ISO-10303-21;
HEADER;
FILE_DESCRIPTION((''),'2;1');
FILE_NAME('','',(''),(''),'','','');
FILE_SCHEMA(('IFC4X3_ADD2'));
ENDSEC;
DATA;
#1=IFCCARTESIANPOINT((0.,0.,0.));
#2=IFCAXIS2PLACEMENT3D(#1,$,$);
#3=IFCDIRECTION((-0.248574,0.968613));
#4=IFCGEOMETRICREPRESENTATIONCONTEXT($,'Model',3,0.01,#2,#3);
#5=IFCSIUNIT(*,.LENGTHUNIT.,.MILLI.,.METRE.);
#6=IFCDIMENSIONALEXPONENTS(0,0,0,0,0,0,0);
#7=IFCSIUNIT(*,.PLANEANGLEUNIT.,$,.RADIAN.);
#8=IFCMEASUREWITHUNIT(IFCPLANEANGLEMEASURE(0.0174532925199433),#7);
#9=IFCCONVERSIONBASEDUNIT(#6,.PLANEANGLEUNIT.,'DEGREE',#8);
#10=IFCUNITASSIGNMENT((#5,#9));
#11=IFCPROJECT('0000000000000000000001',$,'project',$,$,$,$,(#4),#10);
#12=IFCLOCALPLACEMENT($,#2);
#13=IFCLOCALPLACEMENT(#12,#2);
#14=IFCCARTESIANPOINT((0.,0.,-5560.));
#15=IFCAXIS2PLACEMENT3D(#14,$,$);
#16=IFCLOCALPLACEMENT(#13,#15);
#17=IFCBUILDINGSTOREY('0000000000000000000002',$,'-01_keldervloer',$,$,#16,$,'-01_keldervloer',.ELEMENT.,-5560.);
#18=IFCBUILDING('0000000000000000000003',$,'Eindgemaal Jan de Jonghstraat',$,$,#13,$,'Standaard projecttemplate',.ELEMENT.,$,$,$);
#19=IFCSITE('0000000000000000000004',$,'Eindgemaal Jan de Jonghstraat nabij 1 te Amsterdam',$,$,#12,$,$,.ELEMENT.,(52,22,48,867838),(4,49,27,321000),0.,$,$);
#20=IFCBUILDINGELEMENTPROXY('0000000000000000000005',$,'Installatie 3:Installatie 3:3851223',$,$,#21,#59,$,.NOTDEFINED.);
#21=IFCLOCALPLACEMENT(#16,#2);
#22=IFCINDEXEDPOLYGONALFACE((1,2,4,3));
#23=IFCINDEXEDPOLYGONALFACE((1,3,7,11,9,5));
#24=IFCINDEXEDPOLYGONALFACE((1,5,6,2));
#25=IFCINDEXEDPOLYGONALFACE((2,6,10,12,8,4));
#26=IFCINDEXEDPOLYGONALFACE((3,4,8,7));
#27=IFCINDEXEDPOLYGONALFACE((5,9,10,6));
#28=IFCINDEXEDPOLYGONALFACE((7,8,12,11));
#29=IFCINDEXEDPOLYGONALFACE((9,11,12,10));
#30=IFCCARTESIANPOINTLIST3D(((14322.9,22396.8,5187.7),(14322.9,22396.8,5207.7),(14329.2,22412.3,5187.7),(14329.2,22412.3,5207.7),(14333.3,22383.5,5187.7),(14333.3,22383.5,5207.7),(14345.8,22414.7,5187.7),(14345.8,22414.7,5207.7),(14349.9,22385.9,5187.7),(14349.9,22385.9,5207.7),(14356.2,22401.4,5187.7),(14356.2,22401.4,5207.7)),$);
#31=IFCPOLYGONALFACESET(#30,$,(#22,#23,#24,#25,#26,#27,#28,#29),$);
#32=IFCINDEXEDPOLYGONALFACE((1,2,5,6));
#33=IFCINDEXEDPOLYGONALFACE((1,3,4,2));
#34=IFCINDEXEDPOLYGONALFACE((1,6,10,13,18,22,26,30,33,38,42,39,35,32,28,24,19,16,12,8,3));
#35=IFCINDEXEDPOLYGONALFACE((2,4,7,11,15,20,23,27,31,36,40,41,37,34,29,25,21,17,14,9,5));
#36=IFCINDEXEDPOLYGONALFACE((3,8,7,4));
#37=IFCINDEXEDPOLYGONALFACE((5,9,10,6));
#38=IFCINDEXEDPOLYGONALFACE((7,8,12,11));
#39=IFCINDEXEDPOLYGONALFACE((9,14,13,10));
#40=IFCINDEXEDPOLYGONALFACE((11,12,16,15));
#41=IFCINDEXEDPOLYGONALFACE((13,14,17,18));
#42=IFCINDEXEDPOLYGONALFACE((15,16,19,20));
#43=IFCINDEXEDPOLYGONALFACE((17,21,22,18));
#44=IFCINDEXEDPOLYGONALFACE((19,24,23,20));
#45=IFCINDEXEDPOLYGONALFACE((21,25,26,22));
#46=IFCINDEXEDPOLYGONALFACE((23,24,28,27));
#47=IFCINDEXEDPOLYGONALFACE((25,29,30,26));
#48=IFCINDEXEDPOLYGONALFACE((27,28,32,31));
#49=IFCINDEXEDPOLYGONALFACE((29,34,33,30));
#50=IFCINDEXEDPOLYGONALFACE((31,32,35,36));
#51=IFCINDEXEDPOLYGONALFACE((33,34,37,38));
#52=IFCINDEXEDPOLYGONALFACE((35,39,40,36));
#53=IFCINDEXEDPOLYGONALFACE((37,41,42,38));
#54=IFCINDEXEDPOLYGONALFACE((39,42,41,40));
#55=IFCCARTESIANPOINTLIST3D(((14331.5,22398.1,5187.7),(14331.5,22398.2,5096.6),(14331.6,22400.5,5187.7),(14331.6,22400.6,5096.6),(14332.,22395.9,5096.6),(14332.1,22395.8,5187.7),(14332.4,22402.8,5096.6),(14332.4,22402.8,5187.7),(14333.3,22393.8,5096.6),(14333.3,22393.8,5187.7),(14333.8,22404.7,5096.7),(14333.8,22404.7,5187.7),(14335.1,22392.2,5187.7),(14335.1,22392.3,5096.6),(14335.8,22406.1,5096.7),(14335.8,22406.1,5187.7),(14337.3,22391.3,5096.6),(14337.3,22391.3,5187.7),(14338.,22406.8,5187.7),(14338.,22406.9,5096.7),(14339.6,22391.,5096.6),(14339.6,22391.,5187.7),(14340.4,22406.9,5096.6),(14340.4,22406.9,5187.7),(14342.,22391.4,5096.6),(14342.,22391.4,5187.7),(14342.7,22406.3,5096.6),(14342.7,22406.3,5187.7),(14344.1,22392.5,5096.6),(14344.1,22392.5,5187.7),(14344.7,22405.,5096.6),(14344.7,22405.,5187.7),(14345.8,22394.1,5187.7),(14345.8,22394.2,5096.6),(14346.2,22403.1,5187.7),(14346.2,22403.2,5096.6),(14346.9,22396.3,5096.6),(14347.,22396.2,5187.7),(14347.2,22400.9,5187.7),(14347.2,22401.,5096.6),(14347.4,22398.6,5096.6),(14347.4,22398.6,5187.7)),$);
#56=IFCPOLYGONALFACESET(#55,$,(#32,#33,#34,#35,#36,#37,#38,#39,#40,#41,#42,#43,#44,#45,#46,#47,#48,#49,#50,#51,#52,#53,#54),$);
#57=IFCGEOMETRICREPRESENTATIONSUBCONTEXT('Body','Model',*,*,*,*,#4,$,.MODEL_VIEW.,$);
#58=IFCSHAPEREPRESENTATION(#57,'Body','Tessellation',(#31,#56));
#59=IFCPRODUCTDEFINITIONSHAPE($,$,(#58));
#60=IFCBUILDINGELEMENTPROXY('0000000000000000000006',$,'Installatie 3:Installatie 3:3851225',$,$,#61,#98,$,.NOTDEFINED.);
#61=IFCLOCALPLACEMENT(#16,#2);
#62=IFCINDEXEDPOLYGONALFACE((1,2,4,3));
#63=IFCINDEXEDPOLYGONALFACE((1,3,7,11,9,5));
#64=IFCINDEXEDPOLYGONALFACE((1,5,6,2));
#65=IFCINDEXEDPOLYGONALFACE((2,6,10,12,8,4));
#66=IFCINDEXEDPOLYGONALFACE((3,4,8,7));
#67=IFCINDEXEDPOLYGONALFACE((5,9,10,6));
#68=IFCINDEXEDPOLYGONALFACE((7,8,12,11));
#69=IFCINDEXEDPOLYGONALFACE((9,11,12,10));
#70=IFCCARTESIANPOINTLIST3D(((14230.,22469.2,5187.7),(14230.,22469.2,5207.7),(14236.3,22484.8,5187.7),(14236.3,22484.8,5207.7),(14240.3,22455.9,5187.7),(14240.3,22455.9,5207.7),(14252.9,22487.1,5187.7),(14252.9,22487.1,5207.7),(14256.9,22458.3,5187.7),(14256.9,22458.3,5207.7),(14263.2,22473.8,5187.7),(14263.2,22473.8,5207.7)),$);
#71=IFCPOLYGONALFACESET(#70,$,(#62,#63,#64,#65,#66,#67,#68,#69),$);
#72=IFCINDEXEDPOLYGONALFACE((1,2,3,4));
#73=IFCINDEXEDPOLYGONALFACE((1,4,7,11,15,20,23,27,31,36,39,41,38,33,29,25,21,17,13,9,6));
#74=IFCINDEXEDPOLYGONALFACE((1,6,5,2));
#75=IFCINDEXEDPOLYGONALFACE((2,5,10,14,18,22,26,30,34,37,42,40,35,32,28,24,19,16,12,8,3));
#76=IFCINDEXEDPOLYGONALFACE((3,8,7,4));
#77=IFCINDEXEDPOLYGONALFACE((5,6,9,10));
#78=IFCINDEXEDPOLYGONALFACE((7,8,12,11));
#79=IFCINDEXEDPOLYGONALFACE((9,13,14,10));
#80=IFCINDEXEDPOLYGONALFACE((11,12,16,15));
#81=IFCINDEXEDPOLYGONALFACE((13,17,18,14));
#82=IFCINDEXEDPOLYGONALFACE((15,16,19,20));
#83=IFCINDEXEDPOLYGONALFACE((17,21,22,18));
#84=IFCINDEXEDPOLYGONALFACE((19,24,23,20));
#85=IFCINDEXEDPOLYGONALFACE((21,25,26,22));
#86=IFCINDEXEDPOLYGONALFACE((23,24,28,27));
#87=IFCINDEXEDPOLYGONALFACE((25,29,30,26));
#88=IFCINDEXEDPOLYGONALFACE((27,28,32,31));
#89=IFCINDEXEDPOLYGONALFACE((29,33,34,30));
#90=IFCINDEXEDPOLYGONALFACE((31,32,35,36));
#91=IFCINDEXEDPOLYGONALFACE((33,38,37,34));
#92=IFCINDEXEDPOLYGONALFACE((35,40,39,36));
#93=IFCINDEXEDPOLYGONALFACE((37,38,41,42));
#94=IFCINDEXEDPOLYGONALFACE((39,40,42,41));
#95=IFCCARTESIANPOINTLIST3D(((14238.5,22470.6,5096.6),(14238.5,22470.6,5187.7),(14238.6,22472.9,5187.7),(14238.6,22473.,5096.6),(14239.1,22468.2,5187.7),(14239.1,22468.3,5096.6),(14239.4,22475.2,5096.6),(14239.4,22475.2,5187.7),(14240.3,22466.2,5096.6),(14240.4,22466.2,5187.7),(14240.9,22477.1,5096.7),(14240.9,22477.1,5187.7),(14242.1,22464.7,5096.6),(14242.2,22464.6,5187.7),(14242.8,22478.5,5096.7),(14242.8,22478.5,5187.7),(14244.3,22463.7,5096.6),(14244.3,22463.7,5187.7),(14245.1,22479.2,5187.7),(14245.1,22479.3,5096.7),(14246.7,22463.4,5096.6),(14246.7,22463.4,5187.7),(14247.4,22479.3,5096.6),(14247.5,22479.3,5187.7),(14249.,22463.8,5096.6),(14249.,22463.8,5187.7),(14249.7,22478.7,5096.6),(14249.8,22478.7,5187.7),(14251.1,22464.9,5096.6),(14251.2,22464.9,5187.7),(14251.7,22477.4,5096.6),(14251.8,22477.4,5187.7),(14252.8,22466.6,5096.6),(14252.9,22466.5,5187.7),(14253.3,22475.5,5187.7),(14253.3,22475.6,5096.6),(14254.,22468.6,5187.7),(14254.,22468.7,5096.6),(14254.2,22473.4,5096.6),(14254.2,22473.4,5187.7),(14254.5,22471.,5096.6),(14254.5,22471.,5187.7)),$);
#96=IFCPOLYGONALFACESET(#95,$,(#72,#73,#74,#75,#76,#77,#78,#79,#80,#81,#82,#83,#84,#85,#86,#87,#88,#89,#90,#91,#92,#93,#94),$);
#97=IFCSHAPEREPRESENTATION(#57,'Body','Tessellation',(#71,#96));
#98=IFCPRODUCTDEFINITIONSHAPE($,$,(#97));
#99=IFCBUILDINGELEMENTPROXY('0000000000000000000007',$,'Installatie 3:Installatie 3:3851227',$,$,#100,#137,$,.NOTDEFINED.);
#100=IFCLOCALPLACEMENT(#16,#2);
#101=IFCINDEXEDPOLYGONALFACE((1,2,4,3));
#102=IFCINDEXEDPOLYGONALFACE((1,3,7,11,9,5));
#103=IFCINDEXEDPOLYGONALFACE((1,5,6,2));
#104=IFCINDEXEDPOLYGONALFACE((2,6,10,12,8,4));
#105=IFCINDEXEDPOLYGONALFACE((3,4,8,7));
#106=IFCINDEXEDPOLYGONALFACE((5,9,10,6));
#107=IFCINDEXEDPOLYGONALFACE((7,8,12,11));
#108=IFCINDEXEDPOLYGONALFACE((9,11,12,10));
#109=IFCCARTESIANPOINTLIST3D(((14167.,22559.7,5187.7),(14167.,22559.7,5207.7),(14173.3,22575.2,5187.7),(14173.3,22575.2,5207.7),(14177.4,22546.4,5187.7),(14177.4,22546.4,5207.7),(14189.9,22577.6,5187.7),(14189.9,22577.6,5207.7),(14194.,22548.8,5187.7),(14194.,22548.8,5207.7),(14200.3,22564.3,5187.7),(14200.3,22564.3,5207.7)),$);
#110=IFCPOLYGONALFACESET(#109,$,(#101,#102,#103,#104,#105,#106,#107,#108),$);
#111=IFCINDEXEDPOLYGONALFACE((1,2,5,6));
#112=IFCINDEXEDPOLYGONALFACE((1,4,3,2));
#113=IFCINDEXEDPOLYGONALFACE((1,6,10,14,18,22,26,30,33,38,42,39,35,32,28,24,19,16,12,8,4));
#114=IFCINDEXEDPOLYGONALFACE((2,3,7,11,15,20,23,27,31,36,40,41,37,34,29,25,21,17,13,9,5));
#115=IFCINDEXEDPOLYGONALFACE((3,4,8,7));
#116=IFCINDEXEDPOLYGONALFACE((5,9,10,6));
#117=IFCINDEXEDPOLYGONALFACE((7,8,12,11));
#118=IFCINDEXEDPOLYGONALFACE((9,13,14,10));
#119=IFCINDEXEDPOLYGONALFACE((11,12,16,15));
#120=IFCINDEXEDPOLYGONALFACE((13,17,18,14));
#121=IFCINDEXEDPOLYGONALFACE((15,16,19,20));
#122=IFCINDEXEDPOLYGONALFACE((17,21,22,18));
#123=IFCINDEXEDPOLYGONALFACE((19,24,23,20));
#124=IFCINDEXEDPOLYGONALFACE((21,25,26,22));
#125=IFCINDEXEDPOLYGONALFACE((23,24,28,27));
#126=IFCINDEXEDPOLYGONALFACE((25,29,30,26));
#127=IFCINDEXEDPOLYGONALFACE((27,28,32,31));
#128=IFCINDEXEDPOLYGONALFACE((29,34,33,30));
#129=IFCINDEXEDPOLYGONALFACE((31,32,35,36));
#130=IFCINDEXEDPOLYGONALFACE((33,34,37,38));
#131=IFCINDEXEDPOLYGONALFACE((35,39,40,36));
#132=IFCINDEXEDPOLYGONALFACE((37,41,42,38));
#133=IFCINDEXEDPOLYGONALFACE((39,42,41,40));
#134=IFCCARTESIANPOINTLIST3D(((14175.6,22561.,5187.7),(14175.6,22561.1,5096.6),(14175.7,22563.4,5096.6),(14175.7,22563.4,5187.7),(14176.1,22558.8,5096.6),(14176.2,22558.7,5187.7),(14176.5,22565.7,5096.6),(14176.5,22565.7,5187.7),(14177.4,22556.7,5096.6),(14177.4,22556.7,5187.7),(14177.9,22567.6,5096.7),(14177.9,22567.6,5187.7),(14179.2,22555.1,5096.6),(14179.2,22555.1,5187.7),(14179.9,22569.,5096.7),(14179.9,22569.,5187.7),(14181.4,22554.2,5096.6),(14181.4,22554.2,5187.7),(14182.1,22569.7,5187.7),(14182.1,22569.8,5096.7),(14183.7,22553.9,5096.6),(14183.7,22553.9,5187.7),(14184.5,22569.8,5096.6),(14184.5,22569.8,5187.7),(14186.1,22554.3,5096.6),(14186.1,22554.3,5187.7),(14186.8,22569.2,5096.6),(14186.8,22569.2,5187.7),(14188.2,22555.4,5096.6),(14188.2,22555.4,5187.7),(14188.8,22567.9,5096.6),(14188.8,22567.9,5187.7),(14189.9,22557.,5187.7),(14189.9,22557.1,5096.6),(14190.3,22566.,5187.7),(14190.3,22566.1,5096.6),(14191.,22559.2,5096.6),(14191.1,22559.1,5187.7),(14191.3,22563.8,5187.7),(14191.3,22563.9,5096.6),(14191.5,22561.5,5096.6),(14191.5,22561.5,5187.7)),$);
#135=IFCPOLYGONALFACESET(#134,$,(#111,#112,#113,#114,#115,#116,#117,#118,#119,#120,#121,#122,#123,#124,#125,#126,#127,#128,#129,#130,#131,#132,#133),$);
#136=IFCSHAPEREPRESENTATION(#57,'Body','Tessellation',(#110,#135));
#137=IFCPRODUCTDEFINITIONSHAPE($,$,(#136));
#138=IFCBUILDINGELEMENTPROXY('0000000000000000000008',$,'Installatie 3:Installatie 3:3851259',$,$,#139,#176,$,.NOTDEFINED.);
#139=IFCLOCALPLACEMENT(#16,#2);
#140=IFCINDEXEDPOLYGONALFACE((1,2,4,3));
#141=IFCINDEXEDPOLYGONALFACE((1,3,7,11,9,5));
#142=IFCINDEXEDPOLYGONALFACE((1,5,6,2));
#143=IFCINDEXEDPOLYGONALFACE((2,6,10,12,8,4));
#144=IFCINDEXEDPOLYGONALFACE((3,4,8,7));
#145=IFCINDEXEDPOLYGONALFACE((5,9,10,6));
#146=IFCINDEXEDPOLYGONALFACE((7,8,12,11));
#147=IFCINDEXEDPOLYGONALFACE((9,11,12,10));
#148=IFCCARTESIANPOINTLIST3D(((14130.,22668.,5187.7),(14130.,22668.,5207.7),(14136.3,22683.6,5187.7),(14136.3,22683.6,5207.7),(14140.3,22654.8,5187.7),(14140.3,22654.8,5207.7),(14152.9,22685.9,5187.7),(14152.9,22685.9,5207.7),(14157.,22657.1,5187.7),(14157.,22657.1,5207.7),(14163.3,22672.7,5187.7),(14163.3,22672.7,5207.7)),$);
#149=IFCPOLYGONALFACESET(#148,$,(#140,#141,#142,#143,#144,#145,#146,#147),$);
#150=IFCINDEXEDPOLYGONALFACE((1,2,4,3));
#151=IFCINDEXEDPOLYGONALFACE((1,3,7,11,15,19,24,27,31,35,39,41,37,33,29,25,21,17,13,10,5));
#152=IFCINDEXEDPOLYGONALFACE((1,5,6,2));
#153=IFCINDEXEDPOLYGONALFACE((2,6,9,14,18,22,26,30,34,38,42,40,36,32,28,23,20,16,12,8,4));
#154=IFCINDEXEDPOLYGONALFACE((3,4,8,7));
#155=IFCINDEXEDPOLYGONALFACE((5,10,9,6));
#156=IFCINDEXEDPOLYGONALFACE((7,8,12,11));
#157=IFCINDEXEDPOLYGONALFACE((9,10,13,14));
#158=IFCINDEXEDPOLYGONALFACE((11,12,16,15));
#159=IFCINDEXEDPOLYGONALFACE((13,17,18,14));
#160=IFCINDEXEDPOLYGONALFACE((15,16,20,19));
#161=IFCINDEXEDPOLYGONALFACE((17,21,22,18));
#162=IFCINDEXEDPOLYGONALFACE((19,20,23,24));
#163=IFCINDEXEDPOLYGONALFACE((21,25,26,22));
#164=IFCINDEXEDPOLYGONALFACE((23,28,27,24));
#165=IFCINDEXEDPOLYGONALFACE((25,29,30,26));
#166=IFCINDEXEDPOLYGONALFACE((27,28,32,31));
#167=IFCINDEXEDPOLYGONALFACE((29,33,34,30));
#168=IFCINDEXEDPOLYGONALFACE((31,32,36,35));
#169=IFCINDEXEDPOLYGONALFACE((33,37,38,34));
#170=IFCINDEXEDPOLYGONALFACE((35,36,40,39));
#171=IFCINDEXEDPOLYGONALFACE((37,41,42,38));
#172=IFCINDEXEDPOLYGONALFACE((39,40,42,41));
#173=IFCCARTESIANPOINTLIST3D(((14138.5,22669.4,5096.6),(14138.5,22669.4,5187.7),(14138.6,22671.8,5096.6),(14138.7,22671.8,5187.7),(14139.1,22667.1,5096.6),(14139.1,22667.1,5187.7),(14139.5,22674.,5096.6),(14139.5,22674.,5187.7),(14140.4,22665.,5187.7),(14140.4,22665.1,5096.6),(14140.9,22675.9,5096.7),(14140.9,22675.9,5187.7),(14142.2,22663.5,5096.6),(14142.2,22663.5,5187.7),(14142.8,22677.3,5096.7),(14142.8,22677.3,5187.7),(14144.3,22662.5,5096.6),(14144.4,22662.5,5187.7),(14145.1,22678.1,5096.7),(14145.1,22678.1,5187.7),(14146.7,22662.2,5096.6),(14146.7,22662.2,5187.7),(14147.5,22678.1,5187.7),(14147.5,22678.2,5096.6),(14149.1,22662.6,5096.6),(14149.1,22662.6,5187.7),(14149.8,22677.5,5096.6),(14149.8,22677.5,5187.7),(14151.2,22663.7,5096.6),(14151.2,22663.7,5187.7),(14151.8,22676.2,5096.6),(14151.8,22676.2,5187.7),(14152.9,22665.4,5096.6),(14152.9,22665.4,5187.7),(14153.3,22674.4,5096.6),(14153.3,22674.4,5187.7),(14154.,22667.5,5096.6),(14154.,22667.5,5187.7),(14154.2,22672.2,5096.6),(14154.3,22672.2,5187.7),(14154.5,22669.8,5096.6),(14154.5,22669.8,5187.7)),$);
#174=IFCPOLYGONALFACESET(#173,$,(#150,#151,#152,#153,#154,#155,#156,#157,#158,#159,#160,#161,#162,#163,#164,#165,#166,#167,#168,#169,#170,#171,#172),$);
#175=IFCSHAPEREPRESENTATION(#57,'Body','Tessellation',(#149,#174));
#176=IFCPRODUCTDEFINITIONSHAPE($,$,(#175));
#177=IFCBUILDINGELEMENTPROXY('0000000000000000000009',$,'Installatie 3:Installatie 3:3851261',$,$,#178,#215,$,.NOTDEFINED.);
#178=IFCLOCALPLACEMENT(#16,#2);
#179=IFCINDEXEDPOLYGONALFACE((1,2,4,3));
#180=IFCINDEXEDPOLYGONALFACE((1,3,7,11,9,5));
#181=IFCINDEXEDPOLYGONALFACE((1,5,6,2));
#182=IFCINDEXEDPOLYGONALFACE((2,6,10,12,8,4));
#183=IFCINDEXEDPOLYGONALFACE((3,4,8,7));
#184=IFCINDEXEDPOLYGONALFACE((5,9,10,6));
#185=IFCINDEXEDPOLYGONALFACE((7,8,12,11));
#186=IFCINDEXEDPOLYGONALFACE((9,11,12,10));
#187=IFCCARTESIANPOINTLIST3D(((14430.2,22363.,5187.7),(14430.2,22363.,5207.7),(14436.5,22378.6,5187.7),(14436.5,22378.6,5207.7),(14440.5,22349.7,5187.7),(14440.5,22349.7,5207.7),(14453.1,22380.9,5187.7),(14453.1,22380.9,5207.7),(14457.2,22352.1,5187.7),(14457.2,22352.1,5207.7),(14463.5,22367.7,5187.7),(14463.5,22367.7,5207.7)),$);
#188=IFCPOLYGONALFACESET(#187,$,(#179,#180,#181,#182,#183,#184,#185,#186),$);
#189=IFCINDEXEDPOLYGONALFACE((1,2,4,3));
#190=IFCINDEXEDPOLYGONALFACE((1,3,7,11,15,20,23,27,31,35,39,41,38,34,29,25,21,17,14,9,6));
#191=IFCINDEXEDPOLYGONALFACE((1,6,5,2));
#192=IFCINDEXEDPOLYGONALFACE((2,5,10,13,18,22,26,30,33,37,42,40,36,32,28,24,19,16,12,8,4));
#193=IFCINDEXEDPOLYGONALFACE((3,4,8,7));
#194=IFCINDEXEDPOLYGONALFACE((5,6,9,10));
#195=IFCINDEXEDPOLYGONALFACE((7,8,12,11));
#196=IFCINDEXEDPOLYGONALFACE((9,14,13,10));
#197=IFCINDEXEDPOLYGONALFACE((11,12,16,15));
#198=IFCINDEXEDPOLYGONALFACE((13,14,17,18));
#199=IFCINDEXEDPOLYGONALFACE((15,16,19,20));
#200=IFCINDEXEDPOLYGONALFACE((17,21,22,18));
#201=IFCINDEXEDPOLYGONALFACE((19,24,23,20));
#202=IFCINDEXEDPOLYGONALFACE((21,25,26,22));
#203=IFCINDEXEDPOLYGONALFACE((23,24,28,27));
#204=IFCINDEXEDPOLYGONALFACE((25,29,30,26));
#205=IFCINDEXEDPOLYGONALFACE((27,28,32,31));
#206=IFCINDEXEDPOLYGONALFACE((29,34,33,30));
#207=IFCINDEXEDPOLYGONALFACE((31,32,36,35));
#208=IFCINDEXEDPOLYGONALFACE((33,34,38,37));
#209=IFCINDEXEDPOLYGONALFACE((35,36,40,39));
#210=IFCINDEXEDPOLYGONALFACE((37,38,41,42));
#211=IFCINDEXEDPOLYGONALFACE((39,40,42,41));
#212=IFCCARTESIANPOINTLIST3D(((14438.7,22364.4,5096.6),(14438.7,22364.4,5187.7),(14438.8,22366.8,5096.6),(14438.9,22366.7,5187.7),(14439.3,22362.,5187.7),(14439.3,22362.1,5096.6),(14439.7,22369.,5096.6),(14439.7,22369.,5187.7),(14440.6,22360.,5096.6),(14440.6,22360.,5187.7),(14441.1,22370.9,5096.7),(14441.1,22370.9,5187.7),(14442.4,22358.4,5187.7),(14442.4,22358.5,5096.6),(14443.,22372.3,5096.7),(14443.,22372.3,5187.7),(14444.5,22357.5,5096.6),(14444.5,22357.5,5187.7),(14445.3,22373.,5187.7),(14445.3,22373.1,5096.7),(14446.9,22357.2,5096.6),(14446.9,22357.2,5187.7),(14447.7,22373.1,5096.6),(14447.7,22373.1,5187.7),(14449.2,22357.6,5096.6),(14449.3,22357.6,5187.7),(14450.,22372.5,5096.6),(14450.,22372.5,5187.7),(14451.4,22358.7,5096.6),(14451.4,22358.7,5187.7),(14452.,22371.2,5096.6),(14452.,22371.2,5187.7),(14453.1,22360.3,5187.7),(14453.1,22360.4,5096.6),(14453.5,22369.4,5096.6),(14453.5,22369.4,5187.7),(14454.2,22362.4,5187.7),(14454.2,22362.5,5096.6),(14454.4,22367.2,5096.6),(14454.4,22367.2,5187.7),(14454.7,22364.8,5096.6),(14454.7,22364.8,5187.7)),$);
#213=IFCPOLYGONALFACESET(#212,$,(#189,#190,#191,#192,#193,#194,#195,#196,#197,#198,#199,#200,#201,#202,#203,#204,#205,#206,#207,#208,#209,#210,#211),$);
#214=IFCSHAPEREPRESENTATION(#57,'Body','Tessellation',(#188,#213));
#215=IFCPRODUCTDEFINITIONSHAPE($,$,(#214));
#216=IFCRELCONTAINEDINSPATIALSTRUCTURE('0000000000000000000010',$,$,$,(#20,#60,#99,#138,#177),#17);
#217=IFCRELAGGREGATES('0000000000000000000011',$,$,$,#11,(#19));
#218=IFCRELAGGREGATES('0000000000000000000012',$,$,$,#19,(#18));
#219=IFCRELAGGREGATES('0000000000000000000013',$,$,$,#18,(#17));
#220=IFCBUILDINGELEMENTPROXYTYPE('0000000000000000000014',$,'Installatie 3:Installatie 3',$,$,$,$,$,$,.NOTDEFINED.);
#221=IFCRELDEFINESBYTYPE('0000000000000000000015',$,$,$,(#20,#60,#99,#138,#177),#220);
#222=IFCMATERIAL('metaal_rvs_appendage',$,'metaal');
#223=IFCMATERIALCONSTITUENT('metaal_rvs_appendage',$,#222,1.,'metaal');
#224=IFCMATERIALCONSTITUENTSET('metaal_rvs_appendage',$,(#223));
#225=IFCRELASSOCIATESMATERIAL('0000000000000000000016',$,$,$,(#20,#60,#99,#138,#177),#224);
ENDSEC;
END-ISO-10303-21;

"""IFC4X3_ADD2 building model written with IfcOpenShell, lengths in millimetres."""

from ifc_helpers import new_model, entity, si_unit, converted_unit, direction, frame, frame_2d, origin, place, context, subcontext, project, spatial, polyline, circle, outline, extrude, source, transform, mapped, material, constituent, constituent_set, type_object, type_shapes, element, save


model = new_model("IFC4X3_ADD2")

# Units and contexts
model_context = context("Model", 3, precision=0.01, world=origin(), true_north=direction((-0.248574, 0.968613)))
body_context = subcontext(model_context, "Body", "Model", "MODEL_VIEW")
ifc_project = project(units=[si_unit("LENGTHUNIT", "METRE", prefix="MILLI"), converted_unit("PLANEANGLEUNIT", "DEGREE", entity("IfcPlaneAngleMeasure", 0.0174532925199433), si_unit("PLANEANGLEUNIT", "RADIAN"), dimensions=[0, 0, 0, 0, 0, 0, 0])], contexts=[model_context])

# Site, building, storey
site_placement = place(None, origin())
site = spatial("IfcSite", under=ifc_project, at=site_placement, Name="Eindgemaal Jan de Jonghstraat nabij 1 te Amsterdam", CompositionType="ELEMENT", RefLatitude=(52, 22, 48, 867838), RefLongitude=(4, 49, 27, 321000), RefElevation=0.0)
building_placement = place(site_placement, origin())
building = spatial("IfcBuilding", under=site, at=building_placement, Name="Eindgemaal Jan de Jonghstraat", LongName="Standaard projecttemplate", CompositionType="ELEMENT")
storey_placement = place(building_placement, frame((0.0, 0.0, -5560.0)))
storey = spatial("IfcBuildingStorey", under=building, at=storey_placement, Name="-01_keldervloer", LongName="-01_keldervloer", CompositionType="ELEMENT", Elevation=-5560.0)

# Building element proxies
ifc_material_1 = material(Name="metaal_rvs_appendage", Category="metaal")
ifc_constituent_1 = constituent(ifc_material_1, Name="metaal_rvs_appendage", Category="metaal", fraction=1.0)
ifc_constituent_set_1 = constituent_set(constituents=[ifc_constituent_1], Name="metaal_rvs_appendage")
building_element_proxy_type_1 = type_object("IfcBuildingElementProxyType", Name="Installatie 3:Installatie 3", PredefinedType="NOTDEFINED")
shared_shape_1 = source(origin(), body_context, "Body", "SweptSolid", [
    extrude(outline(polyline([(-8.4, -14.6), (8.4, -14.6), (16.8, 0.0), (8.4, 14.6), (-8.4, 14.6), (-16.8, 0.0), (-8.4, -14.6)])), frame((0.0, 0.0, 41.5), z_axis=(0.0, 0.0, 1.0), x_axis=(-0.400458, 0.916315, 0.0)), (0.0, 0.0, 1.0), 20.0),
    extrude(circle(Radius=8.0, at=frame_2d((0.0, 0.0), x_axis=(1.0, 0.0))), frame((-0.2, -0.1, -49.5), z_axis=(0.000101, -0.000286, 1.0), x_axis=(1.0, 0.0, -0.000101)), (0.0, 0.0, 1.0), 91.1),
])
type_shapes(building_element_proxy_type_1, [shared_shape_1])
for number, where, z_axis, x_axis, name in (
    (1, (14339.6, 22399.1, 5146.2), (0.0, 0.0, 1.0), (0.968613, 0.248574, 0.0), "Installatie 3:Installatie 3:3851223"),
    (2, (14246.6, 22471.5, 5146.2), (0.0, 0.0, 1.0), (0.968613, 0.248574, 0.0), "Installatie 3:Installatie 3:3851225"),
    (3, (14183.6, 22562.0, 5146.2), (0.0, 0.0, 1.0), (0.968613, 0.248574, 0.0), "Installatie 3:Installatie 3:3851227"),
    (4, (14146.6, 22670.3, 5146.2), (0.0, 0.0, 1.0), (0.968613, 0.248574, 0.0), "Installatie 3:Installatie 3:3851259"),
    (5, (14446.8, 22365.3, 5146.2), (0.0, 0.0, 1.0), (0.968613, 0.248574, 0.0), "Installatie 3:Installatie 3:3851261"),
):
    element("IfcBuildingElementProxy", number, at=place(storey_placement, frame(where, z_axis=z_axis, x_axis=x_axis)), inside=storey, type_object=building_element_proxy_type_1, material=ifc_constituent_set_1, Name=name, PredefinedType="NOTDEFINED", context=body_context, shape_type="MappedRepresentation", body=[
        mapped(shared_shape_1, transform((0.0, 0.0, 0.0), scale=1.0)),
    ])

save(model, "model.ifc")
